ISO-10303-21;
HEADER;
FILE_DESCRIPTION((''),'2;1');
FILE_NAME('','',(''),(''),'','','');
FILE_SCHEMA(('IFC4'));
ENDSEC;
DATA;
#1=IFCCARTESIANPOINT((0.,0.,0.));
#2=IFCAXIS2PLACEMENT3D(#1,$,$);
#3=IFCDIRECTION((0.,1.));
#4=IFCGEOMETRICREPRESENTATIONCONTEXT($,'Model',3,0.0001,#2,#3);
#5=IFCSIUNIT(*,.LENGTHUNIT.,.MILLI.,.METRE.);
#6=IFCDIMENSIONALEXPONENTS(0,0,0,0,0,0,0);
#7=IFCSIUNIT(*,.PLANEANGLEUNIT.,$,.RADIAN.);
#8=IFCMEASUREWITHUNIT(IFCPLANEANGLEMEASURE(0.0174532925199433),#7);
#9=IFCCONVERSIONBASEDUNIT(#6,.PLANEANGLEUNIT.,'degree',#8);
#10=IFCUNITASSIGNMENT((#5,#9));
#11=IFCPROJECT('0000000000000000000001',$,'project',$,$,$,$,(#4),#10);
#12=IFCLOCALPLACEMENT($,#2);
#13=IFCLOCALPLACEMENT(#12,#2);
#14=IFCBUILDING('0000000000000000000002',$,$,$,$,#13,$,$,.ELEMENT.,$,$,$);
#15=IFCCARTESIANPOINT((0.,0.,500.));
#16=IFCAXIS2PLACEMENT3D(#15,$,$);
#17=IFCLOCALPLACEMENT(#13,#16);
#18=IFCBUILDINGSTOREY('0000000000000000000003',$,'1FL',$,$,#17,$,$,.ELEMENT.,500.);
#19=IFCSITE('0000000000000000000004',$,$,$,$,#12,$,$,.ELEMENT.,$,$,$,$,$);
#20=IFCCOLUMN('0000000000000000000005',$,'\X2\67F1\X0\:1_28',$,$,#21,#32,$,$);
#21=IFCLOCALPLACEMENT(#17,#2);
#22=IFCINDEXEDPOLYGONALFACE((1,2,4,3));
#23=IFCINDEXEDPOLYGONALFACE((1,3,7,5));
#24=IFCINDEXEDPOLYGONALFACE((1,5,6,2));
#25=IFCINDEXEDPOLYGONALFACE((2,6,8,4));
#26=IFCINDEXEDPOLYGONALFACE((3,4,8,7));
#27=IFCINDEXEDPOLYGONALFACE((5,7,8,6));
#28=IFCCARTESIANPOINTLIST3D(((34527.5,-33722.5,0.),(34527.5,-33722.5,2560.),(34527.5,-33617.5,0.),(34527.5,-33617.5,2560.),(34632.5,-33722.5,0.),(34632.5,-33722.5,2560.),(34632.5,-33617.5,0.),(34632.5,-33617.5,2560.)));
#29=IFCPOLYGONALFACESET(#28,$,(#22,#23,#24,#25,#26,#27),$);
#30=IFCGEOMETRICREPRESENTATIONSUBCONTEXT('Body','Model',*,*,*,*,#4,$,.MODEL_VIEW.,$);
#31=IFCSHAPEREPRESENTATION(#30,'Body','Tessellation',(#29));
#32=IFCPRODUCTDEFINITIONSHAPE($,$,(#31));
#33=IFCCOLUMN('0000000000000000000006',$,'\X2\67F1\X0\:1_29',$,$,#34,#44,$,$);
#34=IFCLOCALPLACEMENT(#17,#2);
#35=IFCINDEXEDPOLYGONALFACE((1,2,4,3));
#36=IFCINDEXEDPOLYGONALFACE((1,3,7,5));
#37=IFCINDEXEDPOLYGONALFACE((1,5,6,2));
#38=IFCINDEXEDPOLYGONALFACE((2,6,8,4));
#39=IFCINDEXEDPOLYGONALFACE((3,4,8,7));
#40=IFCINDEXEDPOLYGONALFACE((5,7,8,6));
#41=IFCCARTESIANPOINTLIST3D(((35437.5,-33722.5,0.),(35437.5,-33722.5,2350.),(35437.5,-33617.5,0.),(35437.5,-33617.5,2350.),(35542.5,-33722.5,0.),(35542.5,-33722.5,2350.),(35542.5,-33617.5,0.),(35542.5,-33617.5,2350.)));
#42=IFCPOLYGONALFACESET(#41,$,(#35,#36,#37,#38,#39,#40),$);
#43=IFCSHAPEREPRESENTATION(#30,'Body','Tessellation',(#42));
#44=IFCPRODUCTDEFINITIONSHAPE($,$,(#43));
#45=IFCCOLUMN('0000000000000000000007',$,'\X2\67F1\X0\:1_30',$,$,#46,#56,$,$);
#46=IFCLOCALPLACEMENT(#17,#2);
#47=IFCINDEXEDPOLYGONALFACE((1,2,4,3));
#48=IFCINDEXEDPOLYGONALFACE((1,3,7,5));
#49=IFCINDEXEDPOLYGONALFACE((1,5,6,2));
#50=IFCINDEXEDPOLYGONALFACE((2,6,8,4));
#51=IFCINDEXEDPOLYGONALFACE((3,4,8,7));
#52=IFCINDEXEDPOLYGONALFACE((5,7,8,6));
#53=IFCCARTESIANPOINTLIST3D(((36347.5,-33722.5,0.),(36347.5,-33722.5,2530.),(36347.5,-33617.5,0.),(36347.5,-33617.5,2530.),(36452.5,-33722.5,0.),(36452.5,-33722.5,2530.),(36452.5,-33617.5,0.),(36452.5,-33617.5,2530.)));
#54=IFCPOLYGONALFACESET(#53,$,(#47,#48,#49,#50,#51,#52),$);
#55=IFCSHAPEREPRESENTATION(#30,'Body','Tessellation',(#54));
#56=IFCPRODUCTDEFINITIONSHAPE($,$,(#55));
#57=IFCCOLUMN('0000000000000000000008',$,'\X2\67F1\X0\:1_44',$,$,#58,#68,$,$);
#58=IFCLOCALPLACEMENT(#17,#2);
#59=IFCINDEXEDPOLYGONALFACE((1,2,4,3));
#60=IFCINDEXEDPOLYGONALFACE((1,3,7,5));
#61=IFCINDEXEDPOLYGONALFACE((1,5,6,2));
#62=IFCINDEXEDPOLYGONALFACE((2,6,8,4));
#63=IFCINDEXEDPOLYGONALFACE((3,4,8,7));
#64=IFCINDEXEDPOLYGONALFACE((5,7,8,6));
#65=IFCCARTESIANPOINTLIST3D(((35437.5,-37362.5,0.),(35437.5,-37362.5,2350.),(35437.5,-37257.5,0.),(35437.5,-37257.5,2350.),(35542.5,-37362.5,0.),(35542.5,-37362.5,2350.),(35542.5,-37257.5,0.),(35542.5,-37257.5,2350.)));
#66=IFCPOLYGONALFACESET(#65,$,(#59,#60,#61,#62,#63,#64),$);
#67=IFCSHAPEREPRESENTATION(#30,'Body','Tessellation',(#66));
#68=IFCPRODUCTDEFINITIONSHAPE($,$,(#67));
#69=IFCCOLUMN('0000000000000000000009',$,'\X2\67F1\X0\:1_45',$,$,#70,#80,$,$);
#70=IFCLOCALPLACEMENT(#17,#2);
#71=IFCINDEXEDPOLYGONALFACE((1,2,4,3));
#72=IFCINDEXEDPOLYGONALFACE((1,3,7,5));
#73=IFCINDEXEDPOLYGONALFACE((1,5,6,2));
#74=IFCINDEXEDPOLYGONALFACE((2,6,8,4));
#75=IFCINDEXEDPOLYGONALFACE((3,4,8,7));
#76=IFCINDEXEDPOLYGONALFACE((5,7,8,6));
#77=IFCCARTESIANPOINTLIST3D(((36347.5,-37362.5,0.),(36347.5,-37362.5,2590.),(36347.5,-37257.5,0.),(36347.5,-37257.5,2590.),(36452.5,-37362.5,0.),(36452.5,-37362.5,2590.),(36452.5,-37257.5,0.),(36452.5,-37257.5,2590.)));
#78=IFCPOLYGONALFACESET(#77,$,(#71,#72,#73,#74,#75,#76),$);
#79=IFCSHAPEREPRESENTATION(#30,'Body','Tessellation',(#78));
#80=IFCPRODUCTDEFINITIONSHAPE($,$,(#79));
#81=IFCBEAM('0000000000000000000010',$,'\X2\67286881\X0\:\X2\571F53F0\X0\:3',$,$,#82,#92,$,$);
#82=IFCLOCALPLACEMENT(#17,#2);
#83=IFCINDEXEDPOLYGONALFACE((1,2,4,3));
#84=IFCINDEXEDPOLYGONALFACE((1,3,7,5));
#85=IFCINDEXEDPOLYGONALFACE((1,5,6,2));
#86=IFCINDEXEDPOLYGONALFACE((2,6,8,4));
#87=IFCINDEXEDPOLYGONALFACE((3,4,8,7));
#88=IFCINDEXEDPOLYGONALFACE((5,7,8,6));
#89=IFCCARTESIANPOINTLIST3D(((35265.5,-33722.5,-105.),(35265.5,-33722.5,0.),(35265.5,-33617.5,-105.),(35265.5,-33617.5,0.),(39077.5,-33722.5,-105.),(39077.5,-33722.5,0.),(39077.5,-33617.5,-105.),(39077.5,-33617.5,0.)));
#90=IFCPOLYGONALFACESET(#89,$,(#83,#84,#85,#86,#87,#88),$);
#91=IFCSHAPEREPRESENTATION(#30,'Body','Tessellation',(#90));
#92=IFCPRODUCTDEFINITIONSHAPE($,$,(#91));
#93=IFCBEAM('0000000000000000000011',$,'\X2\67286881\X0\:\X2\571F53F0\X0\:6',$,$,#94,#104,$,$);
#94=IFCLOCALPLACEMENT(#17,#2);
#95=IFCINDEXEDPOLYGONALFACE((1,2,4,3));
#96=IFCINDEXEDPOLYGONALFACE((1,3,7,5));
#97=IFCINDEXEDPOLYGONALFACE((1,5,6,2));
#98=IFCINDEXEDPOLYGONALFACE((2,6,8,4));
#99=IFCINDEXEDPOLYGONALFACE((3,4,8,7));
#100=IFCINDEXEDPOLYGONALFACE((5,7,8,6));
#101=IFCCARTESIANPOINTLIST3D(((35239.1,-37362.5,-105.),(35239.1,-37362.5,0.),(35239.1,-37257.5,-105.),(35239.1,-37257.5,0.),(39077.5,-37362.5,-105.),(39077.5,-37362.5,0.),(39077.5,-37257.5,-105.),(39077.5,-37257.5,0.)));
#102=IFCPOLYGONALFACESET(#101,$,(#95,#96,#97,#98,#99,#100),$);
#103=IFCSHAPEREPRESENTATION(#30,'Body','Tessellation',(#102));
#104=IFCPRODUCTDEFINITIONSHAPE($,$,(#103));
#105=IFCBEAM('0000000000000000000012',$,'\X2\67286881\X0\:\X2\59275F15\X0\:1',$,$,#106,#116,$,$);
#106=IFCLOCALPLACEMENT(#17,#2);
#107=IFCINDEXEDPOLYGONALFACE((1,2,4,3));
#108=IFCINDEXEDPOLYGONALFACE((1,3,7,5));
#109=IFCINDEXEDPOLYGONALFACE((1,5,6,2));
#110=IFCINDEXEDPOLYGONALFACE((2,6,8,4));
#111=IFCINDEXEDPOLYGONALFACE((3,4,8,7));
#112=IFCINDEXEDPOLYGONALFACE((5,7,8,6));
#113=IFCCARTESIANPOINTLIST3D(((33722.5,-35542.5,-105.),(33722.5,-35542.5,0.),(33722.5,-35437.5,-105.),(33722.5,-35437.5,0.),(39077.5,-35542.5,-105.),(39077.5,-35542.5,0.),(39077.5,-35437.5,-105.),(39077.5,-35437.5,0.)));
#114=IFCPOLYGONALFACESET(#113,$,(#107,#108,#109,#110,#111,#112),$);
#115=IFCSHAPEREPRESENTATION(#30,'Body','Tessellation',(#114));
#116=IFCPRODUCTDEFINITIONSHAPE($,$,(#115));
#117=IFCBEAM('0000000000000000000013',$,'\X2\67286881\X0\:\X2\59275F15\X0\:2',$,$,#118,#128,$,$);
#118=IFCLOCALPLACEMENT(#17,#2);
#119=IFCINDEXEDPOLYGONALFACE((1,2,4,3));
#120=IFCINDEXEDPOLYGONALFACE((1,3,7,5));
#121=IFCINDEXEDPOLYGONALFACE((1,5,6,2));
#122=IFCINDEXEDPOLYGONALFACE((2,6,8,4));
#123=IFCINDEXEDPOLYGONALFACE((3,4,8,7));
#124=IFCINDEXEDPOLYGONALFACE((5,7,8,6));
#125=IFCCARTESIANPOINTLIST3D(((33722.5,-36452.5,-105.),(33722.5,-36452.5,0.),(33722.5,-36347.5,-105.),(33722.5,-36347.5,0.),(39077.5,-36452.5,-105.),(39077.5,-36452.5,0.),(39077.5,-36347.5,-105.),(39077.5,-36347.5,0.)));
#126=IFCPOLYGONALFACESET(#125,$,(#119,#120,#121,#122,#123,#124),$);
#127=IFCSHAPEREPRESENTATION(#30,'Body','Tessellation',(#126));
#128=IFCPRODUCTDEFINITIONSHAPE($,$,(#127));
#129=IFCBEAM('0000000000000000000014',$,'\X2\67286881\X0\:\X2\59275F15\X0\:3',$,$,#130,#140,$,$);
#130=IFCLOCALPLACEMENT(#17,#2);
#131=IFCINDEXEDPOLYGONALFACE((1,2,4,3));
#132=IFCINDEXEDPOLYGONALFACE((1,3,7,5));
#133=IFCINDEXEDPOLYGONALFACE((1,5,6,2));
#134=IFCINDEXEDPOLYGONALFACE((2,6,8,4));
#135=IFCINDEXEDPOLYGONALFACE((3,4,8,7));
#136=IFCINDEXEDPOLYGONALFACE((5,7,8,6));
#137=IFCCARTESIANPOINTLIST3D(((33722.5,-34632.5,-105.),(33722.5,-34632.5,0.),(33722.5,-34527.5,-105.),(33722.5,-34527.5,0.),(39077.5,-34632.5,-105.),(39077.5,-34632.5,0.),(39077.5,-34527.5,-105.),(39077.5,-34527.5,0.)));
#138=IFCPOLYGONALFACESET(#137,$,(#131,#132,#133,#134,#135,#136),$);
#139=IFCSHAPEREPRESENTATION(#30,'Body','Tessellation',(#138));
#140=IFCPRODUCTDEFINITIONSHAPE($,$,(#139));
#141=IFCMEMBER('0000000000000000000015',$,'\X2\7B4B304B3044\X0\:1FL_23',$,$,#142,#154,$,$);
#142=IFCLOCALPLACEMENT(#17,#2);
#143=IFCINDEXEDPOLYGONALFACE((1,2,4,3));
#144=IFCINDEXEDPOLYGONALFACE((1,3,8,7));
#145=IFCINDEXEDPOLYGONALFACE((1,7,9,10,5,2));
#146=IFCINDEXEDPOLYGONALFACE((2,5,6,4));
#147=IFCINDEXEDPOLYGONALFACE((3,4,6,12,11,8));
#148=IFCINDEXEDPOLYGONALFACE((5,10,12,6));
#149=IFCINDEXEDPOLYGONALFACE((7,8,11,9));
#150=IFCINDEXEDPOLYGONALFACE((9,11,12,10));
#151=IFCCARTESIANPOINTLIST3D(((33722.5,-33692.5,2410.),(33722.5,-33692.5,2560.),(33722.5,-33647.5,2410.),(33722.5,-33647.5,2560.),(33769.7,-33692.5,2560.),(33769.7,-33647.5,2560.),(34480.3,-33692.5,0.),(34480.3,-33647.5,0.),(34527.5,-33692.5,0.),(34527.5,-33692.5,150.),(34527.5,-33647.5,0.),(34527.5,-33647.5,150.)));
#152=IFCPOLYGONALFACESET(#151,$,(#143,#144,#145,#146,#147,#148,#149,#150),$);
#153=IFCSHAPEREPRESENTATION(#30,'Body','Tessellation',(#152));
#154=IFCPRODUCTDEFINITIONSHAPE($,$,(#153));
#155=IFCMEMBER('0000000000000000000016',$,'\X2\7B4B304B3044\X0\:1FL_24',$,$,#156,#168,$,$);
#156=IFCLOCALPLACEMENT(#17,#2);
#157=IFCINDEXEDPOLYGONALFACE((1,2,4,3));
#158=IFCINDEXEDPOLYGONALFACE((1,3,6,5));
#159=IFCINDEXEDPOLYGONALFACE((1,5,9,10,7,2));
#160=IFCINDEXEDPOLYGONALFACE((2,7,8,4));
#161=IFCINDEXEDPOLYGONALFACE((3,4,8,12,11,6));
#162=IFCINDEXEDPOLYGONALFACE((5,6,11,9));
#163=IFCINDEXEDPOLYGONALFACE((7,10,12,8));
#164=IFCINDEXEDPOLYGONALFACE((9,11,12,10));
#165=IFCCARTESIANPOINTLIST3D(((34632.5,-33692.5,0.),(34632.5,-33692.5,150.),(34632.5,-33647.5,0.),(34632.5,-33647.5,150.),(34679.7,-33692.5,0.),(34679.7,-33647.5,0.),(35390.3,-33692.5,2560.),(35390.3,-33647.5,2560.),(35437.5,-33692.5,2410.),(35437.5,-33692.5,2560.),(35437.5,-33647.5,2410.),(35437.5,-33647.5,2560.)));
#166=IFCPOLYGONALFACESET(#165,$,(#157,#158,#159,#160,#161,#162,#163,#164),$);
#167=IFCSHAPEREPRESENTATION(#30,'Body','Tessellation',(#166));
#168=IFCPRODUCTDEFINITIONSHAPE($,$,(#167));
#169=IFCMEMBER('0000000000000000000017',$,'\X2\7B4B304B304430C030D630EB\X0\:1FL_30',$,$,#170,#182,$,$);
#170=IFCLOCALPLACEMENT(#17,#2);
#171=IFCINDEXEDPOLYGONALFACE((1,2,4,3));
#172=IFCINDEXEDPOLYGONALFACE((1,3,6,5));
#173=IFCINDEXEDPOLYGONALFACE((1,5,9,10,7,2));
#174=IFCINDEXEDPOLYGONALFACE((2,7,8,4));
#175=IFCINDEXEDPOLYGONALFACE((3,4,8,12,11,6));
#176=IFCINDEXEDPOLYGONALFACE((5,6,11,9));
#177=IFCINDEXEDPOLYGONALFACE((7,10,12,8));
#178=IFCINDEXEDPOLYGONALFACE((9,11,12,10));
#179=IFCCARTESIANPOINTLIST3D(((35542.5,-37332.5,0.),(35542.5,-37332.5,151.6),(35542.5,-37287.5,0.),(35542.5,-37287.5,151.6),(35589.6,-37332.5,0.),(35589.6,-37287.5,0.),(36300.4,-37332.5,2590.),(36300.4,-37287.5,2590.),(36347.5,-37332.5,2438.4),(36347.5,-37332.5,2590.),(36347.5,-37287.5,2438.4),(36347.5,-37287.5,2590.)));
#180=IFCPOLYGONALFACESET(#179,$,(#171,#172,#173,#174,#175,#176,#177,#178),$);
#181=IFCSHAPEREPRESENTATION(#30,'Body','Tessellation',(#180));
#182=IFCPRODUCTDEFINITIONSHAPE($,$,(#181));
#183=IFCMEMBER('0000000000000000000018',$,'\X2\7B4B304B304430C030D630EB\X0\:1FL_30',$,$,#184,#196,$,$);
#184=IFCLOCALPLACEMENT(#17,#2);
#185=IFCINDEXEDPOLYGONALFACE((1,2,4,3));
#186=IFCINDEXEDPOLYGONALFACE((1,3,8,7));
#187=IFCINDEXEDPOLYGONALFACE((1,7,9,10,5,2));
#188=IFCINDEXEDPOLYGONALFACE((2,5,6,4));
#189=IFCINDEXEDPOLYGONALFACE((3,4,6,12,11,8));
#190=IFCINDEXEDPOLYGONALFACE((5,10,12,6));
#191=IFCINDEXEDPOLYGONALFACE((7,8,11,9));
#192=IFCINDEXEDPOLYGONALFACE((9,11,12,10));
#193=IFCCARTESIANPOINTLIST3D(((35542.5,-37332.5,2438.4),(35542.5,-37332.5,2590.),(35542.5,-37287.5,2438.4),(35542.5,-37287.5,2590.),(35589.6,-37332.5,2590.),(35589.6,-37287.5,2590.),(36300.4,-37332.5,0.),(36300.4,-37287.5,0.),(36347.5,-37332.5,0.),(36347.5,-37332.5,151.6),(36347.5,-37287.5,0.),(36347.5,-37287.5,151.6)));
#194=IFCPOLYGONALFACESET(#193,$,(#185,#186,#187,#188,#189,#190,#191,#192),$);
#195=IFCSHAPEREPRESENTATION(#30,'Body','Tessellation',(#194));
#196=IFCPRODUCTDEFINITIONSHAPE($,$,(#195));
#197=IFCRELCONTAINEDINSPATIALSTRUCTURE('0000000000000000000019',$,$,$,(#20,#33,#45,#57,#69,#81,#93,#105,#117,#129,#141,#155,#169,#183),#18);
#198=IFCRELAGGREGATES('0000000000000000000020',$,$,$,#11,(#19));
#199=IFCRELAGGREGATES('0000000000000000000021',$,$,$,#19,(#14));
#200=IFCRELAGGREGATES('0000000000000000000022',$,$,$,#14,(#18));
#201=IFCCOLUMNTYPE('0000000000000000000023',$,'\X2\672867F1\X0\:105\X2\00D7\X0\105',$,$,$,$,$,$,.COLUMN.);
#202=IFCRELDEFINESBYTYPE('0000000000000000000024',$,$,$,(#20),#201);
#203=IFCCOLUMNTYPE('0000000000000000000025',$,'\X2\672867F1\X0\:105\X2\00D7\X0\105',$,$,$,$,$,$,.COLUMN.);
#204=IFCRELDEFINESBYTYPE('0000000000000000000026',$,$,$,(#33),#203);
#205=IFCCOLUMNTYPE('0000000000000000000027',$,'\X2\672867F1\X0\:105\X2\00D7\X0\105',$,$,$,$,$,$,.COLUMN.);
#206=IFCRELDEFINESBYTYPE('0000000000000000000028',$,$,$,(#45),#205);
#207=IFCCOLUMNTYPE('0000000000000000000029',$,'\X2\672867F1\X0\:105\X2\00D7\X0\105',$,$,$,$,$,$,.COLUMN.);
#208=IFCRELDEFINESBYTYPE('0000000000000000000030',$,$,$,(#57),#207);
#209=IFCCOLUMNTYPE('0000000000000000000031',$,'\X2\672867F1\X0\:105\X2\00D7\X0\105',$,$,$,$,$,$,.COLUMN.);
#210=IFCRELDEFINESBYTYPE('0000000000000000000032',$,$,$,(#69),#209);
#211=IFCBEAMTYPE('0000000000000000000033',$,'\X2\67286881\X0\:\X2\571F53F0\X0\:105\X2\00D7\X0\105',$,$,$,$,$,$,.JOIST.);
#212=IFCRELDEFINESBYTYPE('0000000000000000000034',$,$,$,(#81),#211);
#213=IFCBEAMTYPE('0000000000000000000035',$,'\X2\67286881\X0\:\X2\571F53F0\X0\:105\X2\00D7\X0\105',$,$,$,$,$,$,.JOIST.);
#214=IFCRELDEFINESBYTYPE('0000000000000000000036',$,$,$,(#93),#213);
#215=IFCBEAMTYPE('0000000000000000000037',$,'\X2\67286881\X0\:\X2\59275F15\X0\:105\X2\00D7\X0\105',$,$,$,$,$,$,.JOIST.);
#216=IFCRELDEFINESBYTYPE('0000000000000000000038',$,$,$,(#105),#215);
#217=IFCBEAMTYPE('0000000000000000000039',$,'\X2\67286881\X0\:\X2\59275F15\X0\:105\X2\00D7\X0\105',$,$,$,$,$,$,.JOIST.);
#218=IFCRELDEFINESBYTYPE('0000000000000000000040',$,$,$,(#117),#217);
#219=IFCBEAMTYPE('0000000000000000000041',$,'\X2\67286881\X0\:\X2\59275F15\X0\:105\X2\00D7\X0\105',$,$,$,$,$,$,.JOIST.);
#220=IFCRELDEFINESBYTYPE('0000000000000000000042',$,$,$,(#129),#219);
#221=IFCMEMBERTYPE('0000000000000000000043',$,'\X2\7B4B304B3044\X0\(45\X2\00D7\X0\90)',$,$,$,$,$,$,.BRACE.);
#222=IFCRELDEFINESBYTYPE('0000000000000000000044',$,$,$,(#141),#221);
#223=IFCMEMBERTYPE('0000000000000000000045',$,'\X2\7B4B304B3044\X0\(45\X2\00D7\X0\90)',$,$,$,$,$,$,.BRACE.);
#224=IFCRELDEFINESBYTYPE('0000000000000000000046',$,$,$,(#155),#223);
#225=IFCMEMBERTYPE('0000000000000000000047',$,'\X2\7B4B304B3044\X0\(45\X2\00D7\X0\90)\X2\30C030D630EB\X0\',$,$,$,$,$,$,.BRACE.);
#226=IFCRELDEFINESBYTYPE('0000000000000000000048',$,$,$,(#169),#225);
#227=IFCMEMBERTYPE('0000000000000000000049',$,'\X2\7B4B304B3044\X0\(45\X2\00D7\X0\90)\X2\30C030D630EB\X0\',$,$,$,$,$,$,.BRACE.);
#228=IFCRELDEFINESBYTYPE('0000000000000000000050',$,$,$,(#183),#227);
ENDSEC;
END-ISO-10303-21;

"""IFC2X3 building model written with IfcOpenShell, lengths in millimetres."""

from ifc_helpers import new_model, entity, si_unit, converted_unit, direction, frame, origin, origin_with_axes, origin_2d, place, context, subcontext, project, spatial, polyline, rectangle, outline, extrude, type_object, element, save


model = new_model("IFC2X3")

# Units and contexts
model_context = context("Model", 3, precision=0.0001, world=origin(), true_north=direction((0.0, 1.0)))
body_context = subcontext(model_context, "Body", "Model", "MODEL_VIEW")
ifc_project = project(units=[si_unit("LENGTHUNIT", "METRE", prefix="MILLI"), converted_unit("PLANEANGLEUNIT", "degree", entity("IfcPlaneAngleMeasure", 0.0174532925199433), si_unit("PLANEANGLEUNIT", "RADIAN"), dimensions=[0, 0, 0, 0, 0, 0, 0])], contexts=[model_context])

# Site, building, storey
site_placement = place(None, origin())
site = spatial("IfcSite", under=ifc_project, at=site_placement, CompositionType="ELEMENT")
building_placement = place(site_placement, origin())
building = spatial("IfcBuilding", under=site, at=building_placement, CompositionType="ELEMENT")
storey_placement = place(building_placement, frame((0.0, 0.0, 500.0)))
storey = spatial("IfcBuildingStorey", under=building, at=storey_placement, Name="1FL", CompositionType="ELEMENT", Elevation=500.0)

# Columns
column_type_1 = type_object("IfcColumnType", Name="木柱:105×105", PredefinedType="COLUMN")
column_1_placement = place(storey_placement, frame((34580.0, -33670.0, 0.0)))
element("IfcColumn", 1, at=column_1_placement, inside=storey, type_object=column_type_1, Name="柱:1_28", context=body_context, shape_type="SweptSolid", body=[
    extrude(rectangle(XDim=105.0, YDim=105.0, at=origin_2d()), origin_with_axes(), (0.0, 0.0, 1.0), 2560.0),
])
column_type_2 = type_object("IfcColumnType", Name="木柱:105×105", PredefinedType="COLUMN")
column_2_placement = place(storey_placement, frame((35490.0, -33670.0, 0.0)))
element("IfcColumn", 2, at=column_2_placement, inside=storey, type_object=column_type_2, Name="柱:1_29", context=body_context, shape_type="SweptSolid", body=[
    extrude(rectangle(XDim=105.0, YDim=105.0, at=origin_2d()), origin_with_axes(), (0.0, 0.0, 1.0), 2350.0),
])
column_type_3 = type_object("IfcColumnType", Name="木柱:105×105", PredefinedType="COLUMN")
column_3_placement = place(storey_placement, frame((36400.0, -33670.0, 0.0)))
element("IfcColumn", 3, at=column_3_placement, inside=storey, type_object=column_type_3, Name="柱:1_30", context=body_context, shape_type="SweptSolid", body=[
    extrude(rectangle(XDim=105.0, YDim=105.0, at=origin_2d()), origin_with_axes(), (0.0, 0.0, 1.0), 2530.0),
])
column_type_4 = type_object("IfcColumnType", Name="木柱:105×105", PredefinedType="COLUMN")
column_4_placement = place(storey_placement, frame((35490.0, -37310.0, 0.0)))
element("IfcColumn", 4, at=column_4_placement, inside=storey, type_object=column_type_4, Name="柱:1_44", context=body_context, shape_type="SweptSolid", body=[
    extrude(rectangle(XDim=105.0, YDim=105.0, at=origin_2d()), origin_with_axes(), (0.0, 0.0, 1.0), 2350.0),
])
column_type_5 = type_object("IfcColumnType", Name="木柱:105×105", PredefinedType="COLUMN")
column_5_placement = place(storey_placement, frame((36400.0, -37310.0, 0.0)))
element("IfcColumn", 5, at=column_5_placement, inside=storey, type_object=column_type_5, Name="柱:1_45", context=body_context, shape_type="SweptSolid", body=[
    extrude(rectangle(XDim=105.0, YDim=105.0, at=origin_2d()), origin_with_axes(), (0.0, 0.0, 1.0), 2590.0),
])

# Beams
beam_type_1 = type_object("IfcBeamType", Name="木梁:土台:105×105", PredefinedType="JOIST")
beam_1_placement = place(storey_placement, frame((35265.5, -33670.0, -52.5), z_axis=(1.0, 0.0, 0.0), x_axis=(0.0, 1.0, 0.0)))
element("IfcBeam", 6, at=beam_1_placement, inside=storey, type_object=beam_type_1, Name="木梁:土台:3", context=body_context, shape_type="SweptSolid", body=[
    extrude(rectangle(XDim=105.0, YDim=105.0, at=origin_2d()), origin_with_axes(), (0.0, 0.0, 1.0), 3812.0),
])
beam_type_2 = type_object("IfcBeamType", Name="木梁:土台:105×105", PredefinedType="JOIST")
beam_2_placement = place(storey_placement, frame((35239.1, -37310.0, -52.5), z_axis=(1.0, 0.0, 0.0), x_axis=(0.0, 1.0, 0.0)))
element("IfcBeam", 7, at=beam_2_placement, inside=storey, type_object=beam_type_2, Name="木梁:土台:6", context=body_context, shape_type="SweptSolid", body=[
    extrude(rectangle(XDim=105.0, YDim=105.0, at=origin_2d()), origin_with_axes(), (0.0, 0.0, 1.0), 3838.4),
])
beam_type_3 = type_object("IfcBeamType", Name="木梁:大引:105×105", PredefinedType="JOIST")
beam_3_placement = place(storey_placement, frame((33722.5, -35490.0, -52.5), z_axis=(1.0, 0.0, 0.0), x_axis=(0.0, 1.0, 0.0)))
element("IfcBeam", 8, at=beam_3_placement, inside=storey, type_object=beam_type_3, Name="木梁:大引:1", context=body_context, shape_type="SweptSolid", body=[
    extrude(rectangle(XDim=105.0, YDim=105.0, at=origin_2d()), origin_with_axes(), (0.0, 0.0, 1.0), 5355.0),
])
beam_type_4 = type_object("IfcBeamType", Name="木梁:大引:105×105", PredefinedType="JOIST")
beam_4_placement = place(storey_placement, frame((33722.5, -36400.0, -52.5), z_axis=(1.0, 0.0, 0.0), x_axis=(0.0, 1.0, 0.0)))
element("IfcBeam", 9, at=beam_4_placement, inside=storey, type_object=beam_type_4, Name="木梁:大引:2", context=body_context, shape_type="SweptSolid", body=[
    extrude(rectangle(XDim=105.0, YDim=105.0, at=origin_2d()), origin_with_axes(), (0.0, 0.0, 1.0), 5355.0),
])
beam_type_5 = type_object("IfcBeamType", Name="木梁:大引:105×105", PredefinedType="JOIST")
beam_5_placement = place(storey_placement, frame((33722.5, -34580.0, -52.5), z_axis=(1.0, 0.0, 0.0), x_axis=(0.0, 1.0, 0.0)))
element("IfcBeam", 10, at=beam_5_placement, inside=storey, type_object=beam_type_5, Name="木梁:大引:3", context=body_context, shape_type="SweptSolid", body=[
    extrude(rectangle(XDim=105.0, YDim=105.0, at=origin_2d()), origin_with_axes(), (0.0, 0.0, 1.0), 5355.0),
])

# Members
member_type_1 = type_object("IfcMemberType", Name="筋かい(45×90)", PredefinedType="BRACE")
member_1_placement = place(storey_placement, frame((34527.5, -33670.0, 0.0), z_axis=(-0.299972, 0.0, 0.953948), x_axis=(0.953948, 0.0, 0.299972)))
element("IfcMember", 11, at=member_1_placement, inside=storey, type_object=member_type_1, Name="筋かい:1FL_23", context=body_context, shape_type="SweptSolid", body=[
    extrude(outline(polyline([(0.0, 0.0), (14.2, -45.0), (2540.5, -45.0), (2683.6, 0.0), (2669.4, 45.0), (143.1, 45.0), (0.0, 0.0)])), frame((0.0, -22.5, 0.0), z_axis=(0.0, 1.0, 0.0), x_axis=(0.0, 0.0, 1.0)), (0.0, 0.0, 1.0), 45.0),
])
member_type_2 = type_object("IfcMemberType", Name="筋かい(45×90)", PredefinedType="BRACE")
member_2_placement = place(storey_placement, frame((34632.5, -33670.0, 0.0), z_axis=(0.299972, 0.0, 0.953948), x_axis=(-0.953948, 0.0, 0.299972)))
element("IfcMember", 12, at=member_2_placement, inside=storey, type_object=member_type_2, Name="筋かい:1FL_24", context=body_context, shape_type="SweptSolid", body=[
    extrude(outline(polyline([(0.0, 0.0), (14.2, -45.0), (2540.5, -45.0), (2683.6, 0.0), (2669.4, 45.0), (143.1, 45.0), (0.0, 0.0)])), frame((0.0, -22.5, 0.0), z_axis=(0.0, 1.0, 0.0), x_axis=(0.0, 0.0, 1.0)), (0.0, 0.0, 1.0), 45.0),
])
member_type_3 = type_object("IfcMemberType", Name="筋かい(45×90)ダブル", PredefinedType="BRACE")
member_3_placement = place(storey_placement, frame((35542.5, -37310.0, 0.0), z_axis=(0.296805, 0.0, 0.954938), x_axis=(-0.954938, 0.0, 0.296805)))
element("IfcMember", 13, at=member_3_placement, inside=storey, type_object=member_type_3, Name="筋かいダブル:1FL_30", context=body_context, shape_type="SweptSolid", body=[
    extrude(outline(polyline([(0.0, 0.0), (14.0, -45.0), (2567.4, -45.0), (2712.2, 0.0), (2698.2, 45.0), (144.8, 45.0), (0.0, 0.0)])), frame((0.0, -22.5, 0.0), z_axis=(0.0, 1.0, 0.0), x_axis=(0.0, 0.0, 1.0)), (0.0, 0.0, 1.0), 45.0),
])
member_type_4 = type_object("IfcMemberType", Name="筋かい(45×90)ダブル", PredefinedType="BRACE")
member_4_placement = place(storey_placement, frame((36347.5, -37310.0, 0.0), z_axis=(-0.296805, 0.0, 0.954938), x_axis=(0.954938, 0.0, 0.296805)))
element("IfcMember", 14, at=member_4_placement, inside=storey, type_object=member_type_4, Name="筋かいダブル:1FL_30", context=body_context, shape_type="SweptSolid", body=[
    extrude(outline(polyline([(0.0, 0.0), (14.0, -45.0), (2567.4, -45.0), (2712.2, 0.0), (2698.2, 45.0), (144.8, 45.0), (0.0, 0.0)])), frame((0.0, -22.5, 0.0), z_axis=(0.0, 1.0, 0.0), x_axis=(0.0, 0.0, 1.0)), (0.0, 0.0, 1.0), 45.0),
])

save(model, "model.ifc")
